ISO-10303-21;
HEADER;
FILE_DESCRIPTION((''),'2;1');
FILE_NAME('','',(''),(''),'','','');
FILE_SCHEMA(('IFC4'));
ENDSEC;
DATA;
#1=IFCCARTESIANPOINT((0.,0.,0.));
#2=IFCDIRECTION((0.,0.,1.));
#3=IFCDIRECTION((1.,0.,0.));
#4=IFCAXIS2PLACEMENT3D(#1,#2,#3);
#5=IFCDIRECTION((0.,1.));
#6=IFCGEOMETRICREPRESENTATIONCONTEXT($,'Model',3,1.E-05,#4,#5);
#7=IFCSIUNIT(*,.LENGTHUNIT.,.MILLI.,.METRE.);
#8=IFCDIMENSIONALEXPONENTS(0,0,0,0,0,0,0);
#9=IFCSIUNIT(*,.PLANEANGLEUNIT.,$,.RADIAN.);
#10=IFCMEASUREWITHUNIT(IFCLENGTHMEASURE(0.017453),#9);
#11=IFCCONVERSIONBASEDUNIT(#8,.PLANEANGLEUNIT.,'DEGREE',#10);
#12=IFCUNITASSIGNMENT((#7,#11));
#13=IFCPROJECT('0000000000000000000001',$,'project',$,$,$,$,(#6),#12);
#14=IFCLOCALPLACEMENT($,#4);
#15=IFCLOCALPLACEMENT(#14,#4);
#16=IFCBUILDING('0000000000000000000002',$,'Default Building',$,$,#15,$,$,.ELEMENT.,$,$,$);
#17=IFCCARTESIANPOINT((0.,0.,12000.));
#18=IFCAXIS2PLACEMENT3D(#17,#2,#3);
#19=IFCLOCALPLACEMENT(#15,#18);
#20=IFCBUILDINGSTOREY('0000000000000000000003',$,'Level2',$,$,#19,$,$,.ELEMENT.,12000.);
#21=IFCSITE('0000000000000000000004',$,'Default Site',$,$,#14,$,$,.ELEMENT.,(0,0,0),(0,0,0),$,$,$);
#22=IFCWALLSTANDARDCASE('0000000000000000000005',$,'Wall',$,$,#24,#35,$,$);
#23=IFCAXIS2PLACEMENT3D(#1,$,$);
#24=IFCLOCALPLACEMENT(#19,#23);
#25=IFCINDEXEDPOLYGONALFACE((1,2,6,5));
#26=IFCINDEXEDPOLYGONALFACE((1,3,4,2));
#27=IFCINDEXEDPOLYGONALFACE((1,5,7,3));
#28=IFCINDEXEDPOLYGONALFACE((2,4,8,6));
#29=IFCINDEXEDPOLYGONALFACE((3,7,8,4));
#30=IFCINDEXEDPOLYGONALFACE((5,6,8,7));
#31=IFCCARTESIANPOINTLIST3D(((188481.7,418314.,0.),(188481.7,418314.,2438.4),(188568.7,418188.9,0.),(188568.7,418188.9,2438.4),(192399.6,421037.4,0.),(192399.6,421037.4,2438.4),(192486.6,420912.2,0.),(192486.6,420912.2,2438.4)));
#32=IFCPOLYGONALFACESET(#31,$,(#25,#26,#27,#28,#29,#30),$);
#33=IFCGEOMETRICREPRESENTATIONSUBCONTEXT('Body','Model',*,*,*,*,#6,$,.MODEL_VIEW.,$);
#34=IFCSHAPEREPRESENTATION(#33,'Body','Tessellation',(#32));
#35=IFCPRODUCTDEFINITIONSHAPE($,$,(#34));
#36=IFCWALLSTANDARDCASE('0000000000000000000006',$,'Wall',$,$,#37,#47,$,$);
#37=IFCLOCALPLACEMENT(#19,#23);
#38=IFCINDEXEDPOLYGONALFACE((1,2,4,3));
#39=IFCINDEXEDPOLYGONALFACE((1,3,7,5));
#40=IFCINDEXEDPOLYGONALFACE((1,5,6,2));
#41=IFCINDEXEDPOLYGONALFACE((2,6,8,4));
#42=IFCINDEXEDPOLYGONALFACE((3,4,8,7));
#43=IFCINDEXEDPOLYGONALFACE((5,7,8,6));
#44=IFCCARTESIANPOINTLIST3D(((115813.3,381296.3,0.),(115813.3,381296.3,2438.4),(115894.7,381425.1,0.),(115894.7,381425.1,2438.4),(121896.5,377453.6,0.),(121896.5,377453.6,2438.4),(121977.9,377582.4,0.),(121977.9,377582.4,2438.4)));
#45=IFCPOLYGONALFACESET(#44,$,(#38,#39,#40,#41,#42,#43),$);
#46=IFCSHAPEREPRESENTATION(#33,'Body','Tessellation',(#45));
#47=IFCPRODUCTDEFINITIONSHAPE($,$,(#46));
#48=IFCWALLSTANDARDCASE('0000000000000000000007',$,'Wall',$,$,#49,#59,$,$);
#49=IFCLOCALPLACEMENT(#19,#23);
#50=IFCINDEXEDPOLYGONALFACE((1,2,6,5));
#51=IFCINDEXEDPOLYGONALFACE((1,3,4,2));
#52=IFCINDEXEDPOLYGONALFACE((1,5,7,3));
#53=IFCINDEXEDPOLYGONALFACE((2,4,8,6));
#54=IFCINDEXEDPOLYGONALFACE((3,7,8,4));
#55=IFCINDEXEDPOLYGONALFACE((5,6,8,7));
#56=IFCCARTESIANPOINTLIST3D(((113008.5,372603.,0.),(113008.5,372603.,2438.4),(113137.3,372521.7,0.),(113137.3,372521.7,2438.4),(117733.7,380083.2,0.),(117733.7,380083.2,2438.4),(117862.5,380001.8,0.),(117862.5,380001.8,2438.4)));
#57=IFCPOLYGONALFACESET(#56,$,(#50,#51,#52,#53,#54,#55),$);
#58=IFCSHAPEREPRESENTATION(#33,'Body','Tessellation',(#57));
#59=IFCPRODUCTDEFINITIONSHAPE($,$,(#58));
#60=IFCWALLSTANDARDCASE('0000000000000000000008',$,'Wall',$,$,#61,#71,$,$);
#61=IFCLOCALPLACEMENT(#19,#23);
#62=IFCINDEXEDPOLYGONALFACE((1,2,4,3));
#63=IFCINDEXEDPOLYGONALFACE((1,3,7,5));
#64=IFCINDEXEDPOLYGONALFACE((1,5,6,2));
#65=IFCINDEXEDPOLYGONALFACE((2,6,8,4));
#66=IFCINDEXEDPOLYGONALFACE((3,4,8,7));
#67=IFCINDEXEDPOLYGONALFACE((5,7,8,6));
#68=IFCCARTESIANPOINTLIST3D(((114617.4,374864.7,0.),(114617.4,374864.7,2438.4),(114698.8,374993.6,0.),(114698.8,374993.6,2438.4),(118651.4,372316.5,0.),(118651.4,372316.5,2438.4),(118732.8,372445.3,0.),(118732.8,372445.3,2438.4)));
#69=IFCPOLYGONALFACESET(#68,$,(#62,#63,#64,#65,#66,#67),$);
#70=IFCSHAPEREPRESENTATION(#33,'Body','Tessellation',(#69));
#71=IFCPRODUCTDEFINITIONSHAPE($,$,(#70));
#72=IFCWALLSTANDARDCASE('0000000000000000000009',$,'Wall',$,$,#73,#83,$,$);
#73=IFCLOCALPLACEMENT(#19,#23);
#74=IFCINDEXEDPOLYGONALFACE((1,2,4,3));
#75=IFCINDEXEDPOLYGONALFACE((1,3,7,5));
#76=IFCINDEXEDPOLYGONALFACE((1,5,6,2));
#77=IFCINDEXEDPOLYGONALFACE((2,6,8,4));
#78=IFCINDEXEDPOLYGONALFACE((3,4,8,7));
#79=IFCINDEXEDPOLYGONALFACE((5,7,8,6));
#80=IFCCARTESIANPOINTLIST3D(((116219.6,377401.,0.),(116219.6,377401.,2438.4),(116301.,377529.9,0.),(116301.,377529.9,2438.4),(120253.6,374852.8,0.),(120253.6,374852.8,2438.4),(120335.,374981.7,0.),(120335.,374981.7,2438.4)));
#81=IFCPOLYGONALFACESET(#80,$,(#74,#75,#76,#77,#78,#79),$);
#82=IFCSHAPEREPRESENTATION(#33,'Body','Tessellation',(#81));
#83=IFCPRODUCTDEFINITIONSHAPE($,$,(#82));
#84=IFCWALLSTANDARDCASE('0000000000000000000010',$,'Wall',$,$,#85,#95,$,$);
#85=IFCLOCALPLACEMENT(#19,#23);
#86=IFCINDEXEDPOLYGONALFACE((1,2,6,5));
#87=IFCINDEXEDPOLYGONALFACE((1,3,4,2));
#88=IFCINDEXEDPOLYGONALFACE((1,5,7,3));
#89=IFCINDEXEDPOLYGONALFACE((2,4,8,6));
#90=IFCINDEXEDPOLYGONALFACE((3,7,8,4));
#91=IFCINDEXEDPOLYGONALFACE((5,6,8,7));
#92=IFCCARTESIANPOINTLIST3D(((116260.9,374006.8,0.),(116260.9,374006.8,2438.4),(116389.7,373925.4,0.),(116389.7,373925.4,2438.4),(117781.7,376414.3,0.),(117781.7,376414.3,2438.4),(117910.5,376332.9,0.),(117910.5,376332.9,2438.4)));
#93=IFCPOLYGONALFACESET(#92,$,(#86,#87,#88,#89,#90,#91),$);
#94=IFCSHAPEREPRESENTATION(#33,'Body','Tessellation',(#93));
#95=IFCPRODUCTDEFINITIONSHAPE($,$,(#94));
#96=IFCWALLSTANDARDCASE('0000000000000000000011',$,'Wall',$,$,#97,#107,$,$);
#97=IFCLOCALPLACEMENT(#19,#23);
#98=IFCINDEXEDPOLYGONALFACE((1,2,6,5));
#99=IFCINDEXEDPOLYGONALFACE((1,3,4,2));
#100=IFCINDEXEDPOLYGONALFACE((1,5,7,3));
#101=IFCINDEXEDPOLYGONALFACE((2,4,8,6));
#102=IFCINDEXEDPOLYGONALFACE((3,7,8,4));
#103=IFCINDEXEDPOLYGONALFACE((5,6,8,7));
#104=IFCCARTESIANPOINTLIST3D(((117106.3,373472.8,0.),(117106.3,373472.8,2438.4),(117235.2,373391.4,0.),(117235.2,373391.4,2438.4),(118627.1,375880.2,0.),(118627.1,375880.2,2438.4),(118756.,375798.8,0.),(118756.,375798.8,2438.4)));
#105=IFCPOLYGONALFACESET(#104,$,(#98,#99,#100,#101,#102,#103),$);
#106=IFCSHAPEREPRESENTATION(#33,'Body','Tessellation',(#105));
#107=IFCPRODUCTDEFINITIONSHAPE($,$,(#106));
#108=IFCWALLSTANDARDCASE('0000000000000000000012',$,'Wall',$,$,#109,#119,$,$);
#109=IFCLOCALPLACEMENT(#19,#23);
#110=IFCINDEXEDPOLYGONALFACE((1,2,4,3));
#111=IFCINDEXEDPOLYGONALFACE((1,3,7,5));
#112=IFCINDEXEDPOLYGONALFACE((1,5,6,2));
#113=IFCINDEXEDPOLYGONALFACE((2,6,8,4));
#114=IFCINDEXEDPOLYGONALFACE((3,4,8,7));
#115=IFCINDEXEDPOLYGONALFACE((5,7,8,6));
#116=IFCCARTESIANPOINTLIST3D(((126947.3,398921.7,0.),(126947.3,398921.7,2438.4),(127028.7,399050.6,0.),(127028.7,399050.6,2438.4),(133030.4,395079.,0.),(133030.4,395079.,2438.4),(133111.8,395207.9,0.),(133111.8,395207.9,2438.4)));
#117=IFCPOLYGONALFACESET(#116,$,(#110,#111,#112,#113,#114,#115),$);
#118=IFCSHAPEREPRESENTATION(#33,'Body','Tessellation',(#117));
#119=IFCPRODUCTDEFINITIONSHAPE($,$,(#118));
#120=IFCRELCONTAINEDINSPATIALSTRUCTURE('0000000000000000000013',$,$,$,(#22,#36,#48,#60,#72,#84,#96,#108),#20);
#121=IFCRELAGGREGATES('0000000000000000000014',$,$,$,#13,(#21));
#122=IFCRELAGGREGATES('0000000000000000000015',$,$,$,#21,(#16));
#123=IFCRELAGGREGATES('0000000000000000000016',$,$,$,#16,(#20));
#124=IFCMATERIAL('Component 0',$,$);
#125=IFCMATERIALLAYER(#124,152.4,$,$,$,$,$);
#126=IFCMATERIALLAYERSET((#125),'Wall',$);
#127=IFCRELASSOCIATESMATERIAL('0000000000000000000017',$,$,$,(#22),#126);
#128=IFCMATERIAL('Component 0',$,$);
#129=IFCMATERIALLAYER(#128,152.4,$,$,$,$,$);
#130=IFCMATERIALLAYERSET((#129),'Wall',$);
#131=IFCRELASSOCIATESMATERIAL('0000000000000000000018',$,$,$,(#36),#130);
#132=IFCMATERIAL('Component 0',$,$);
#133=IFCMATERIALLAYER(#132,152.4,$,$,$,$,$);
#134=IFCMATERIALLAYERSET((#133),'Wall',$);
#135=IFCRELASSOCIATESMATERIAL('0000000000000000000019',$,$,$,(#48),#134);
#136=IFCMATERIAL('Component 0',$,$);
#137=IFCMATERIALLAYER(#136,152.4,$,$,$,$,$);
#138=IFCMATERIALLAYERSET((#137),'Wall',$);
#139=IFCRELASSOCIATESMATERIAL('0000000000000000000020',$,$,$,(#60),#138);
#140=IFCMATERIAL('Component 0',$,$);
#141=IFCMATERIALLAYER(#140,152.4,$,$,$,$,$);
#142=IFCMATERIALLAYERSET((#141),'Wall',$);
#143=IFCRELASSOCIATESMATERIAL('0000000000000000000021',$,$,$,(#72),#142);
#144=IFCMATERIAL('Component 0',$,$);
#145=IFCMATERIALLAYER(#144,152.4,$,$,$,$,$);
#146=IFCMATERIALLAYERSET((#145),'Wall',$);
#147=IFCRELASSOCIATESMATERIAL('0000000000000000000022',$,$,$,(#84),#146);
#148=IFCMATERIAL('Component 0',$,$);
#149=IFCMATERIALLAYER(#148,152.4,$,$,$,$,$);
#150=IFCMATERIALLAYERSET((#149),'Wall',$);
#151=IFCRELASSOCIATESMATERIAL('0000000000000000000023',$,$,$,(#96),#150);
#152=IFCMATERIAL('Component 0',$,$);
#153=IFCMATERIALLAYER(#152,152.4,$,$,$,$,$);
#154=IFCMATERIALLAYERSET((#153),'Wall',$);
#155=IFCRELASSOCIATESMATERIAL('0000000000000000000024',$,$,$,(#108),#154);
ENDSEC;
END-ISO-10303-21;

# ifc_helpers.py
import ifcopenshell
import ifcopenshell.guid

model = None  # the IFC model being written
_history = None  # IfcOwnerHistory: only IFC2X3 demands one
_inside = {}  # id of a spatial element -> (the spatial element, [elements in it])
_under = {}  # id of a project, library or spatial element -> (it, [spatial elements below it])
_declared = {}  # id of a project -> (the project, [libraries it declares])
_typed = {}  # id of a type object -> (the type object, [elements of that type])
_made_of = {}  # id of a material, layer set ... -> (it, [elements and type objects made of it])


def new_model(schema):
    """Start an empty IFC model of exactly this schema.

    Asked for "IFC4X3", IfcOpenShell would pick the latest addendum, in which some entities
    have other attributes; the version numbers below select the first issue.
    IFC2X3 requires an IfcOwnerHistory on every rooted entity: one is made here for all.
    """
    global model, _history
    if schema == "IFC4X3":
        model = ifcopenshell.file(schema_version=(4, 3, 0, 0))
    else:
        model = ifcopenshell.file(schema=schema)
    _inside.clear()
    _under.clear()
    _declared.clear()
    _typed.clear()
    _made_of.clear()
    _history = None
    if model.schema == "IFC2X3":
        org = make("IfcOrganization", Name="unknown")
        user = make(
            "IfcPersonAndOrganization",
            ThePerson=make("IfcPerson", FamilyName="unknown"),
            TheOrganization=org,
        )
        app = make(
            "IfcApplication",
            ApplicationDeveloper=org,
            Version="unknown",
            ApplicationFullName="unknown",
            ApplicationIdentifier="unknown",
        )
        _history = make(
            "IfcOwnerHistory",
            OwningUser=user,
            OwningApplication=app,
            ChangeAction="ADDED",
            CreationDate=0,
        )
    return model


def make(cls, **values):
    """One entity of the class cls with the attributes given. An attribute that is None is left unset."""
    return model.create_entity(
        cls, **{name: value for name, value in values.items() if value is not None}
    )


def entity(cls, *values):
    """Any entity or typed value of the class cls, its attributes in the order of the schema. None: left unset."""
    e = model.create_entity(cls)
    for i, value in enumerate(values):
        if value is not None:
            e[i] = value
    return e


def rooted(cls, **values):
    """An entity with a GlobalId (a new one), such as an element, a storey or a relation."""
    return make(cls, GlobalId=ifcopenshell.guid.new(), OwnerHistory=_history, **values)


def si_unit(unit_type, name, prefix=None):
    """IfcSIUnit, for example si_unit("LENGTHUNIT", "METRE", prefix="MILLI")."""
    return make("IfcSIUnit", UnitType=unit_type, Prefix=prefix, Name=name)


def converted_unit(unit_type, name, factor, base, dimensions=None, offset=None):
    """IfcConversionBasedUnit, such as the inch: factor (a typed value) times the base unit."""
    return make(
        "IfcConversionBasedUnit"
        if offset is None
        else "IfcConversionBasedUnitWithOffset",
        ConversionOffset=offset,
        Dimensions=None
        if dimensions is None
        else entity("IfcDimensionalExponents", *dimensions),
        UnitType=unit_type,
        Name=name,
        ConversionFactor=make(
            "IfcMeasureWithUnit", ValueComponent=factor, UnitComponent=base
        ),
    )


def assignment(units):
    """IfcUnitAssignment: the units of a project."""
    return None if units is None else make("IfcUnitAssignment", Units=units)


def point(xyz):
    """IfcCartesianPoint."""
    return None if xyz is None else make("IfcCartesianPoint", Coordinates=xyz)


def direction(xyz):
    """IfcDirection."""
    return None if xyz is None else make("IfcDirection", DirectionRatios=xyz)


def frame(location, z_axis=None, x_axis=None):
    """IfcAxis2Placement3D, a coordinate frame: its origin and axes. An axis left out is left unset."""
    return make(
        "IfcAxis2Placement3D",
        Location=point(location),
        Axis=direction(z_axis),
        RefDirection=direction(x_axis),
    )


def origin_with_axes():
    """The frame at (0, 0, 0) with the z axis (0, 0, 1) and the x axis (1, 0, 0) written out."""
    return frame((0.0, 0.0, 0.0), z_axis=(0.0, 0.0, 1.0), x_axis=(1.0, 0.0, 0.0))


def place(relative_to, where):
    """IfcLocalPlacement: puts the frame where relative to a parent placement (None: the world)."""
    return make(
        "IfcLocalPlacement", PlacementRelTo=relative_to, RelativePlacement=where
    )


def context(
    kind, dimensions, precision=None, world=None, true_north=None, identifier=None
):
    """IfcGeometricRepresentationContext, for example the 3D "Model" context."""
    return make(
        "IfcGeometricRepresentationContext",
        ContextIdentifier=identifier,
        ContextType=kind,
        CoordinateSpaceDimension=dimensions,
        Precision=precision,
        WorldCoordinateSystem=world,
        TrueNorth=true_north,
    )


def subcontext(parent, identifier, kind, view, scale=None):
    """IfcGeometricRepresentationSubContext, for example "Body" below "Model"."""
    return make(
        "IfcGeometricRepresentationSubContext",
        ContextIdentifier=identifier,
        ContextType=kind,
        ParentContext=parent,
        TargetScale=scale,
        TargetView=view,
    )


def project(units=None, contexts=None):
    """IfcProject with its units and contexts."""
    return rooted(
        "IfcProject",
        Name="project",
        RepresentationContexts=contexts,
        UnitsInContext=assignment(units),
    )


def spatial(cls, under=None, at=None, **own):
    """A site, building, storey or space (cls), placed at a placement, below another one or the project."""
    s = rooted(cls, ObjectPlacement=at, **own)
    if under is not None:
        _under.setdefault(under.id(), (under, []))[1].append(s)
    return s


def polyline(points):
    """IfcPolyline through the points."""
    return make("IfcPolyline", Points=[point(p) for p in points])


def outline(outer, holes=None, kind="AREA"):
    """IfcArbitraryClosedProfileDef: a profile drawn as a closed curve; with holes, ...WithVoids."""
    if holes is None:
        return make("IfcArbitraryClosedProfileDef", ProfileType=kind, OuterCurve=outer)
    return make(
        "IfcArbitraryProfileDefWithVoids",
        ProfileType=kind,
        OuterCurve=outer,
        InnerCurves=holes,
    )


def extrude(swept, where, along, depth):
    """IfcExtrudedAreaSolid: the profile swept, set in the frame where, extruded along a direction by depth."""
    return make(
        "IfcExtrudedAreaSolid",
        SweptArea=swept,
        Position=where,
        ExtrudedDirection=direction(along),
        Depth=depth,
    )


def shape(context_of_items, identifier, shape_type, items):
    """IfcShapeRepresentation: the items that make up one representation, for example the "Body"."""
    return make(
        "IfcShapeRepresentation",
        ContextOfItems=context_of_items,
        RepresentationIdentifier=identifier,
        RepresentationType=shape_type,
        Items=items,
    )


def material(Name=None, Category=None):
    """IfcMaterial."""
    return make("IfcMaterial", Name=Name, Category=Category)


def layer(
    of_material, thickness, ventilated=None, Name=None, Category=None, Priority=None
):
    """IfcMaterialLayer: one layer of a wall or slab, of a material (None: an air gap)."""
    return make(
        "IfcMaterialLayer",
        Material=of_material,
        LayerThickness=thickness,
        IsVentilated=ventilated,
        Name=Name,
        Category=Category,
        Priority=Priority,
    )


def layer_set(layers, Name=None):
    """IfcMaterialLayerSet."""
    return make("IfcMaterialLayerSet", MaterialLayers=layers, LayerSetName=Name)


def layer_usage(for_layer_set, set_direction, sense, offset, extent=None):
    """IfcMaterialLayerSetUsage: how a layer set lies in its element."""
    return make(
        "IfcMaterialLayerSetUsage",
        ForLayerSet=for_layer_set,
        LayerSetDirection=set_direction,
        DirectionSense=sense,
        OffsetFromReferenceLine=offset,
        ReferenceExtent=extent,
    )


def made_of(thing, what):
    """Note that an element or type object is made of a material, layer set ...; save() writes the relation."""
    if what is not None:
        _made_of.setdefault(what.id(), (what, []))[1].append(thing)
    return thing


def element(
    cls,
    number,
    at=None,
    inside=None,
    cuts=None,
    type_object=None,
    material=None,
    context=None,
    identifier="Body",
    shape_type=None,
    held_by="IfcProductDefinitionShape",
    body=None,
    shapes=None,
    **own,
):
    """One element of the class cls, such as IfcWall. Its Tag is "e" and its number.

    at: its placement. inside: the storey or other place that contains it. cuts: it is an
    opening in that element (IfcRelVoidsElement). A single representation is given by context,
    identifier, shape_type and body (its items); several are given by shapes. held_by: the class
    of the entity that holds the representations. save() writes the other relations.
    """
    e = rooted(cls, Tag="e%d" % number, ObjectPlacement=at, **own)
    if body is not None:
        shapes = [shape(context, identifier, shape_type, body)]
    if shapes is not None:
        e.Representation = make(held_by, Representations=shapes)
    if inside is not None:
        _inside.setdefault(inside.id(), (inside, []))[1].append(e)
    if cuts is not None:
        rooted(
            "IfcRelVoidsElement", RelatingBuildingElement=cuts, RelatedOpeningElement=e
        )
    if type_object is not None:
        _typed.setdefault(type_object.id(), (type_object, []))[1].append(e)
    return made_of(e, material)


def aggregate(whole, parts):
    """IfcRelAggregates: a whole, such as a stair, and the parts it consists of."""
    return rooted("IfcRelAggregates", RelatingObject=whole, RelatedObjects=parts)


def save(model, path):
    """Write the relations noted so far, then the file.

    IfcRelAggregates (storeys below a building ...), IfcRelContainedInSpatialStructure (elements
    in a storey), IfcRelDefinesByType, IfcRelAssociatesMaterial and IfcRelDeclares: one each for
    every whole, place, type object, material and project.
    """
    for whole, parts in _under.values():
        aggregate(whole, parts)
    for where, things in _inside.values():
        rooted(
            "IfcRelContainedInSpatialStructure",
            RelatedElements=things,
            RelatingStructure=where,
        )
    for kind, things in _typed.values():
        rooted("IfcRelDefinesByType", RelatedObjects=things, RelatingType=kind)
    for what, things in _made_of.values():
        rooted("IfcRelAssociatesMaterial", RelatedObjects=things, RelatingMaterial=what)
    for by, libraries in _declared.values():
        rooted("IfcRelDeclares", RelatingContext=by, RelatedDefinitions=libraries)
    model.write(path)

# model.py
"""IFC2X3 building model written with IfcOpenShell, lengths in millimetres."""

from ifc_helpers import new_model, entity, si_unit, converted_unit, direction, frame, origin_with_axes, place, context, subcontext, project, spatial, polyline, outline, extrude, material, layer, layer_set, layer_usage, element, save


model = new_model("IFC2X3")

# Units and contexts
model_context = context("Model", 3, precision=1e-05, world=origin_with_axes(), true_north=direction((0.0, 1.0)))
body_context = subcontext(model_context, "Body", "Model", "MODEL_VIEW")
ifc_project = project(units=[si_unit("LENGTHUNIT", "METRE", prefix="MILLI"), converted_unit("PLANEANGLEUNIT", "DEGREE", entity("IfcLengthMeasure", 0.017453), si_unit("PLANEANGLEUNIT", "RADIAN"), dimensions=[0, 0, 0, 0, 0, 0, 0])], contexts=[model_context])

# Site, building, storey
site_placement = place(None, origin_with_axes())
site = spatial("IfcSite", under=ifc_project, at=site_placement, Name="Default Site", CompositionType="ELEMENT", RefLatitude=(0, 0, 0), RefLongitude=(0, 0, 0))
building_placement = place(site_placement, origin_with_axes())
building = spatial("IfcBuilding", under=site, at=building_placement, Name="Default Building", CompositionType="ELEMENT")
storey_placement = place(building_placement, frame((0.0, 0.0, 12000.0), z_axis=(0.0, 0.0, 1.0), x_axis=(1.0, 0.0, 0.0)))
storey = spatial("IfcBuildingStorey", under=building, at=storey_placement, Name="Level2", CompositionType="ELEMENT", Elevation=12000.0)

# Walls
ifc_material_1 = material(Name="Component 0")
ifc_layer_1 = layer(ifc_material_1, 152.4)
ifc_layer_set_1 = layer_set([ifc_layer_1], Name="Wall")
ifc_layer_usage_1 = layer_usage(ifc_layer_set_1, "AXIS2", "POSITIVE", -76.2)
wall_1_placement = place(storey_placement, frame((188462.7, 418208.0, 0.0), z_axis=(0.0, 0.0, 1.0), x_axis=(0.82112, 0.570755, 0.0)))
element("IfcWallStandardCase", 1, at=wall_1_placement, inside=storey, material=ifc_layer_usage_1, Name="Wall", context=body_context, shape_type="SweptSolid", body=[
    extrude(outline(polyline([(76.2, -76.2), (76.2, 76.2), (4847.6, 76.2), (4847.6, -76.2), (76.2, -76.2)])), origin_with_axes(), (0.0, 0.0, 1.0), 2438.4),
])
ifc_material_2 = material(Name="Component 0")
ifc_layer_2 = layer(ifc_material_2, 152.4)
ifc_layer_set_2 = layer_set([ifc_layer_2], Name="Wall")
ifc_layer_usage_2 = layer_usage(ifc_layer_set_2, "AXIS2", "POSITIVE", -76.2)
wall_2_placement = place(storey_placement, frame((122001.6, 377477.3, 0.0), z_axis=(0.0, 0.0, 1.0), x_axis=(-0.845443, 0.534065, 0.0)))
element("IfcWallStandardCase", 2, at=wall_2_placement, inside=storey, material=ifc_layer_usage_2, Name="Wall", context=body_context, shape_type="SweptSolid", body=[
    extrude(outline(polyline([(76.2, -76.2), (76.2, 76.2), (7271.4, 76.2), (7271.4, -76.2), (76.2, -76.2)])), origin_with_axes(), (0.0, 0.0, 1.0), 2438.4),
])
ifc_material_3 = material(Name="Component 0")
ifc_layer_3 = layer(ifc_material_3, 152.4)
ifc_layer_set_3 = layer_set([ifc_layer_3], Name="Wall")
ifc_layer_usage_3 = layer_usage(ifc_layer_set_3, "AXIS2", "POSITIVE", -76.2)
wall_3_placement = place(storey_placement, frame((113032.2, 372497.9, 0.0), z_axis=(0.0, 0.0, 1.0), x_axis=(0.534065, 0.845443, 0.0)))
element("IfcWallStandardCase", 3, at=wall_3_placement, inside=storey, material=ifc_layer_usage_3, Name="Wall", context=body_context, shape_type="SweptSolid", body=[
    extrude(outline(polyline([(76.2, -76.2), (76.2, 76.2), (8923.8, 76.2), (8923.8, -76.2), (76.2, -76.2)])), origin_with_axes(), (0.0, 0.0, 1.0), 2438.4),
])
ifc_material_4 = material(Name="Component 0")
ifc_layer_4 = layer(ifc_material_4, 152.4)
ifc_layer_set_4 = layer_set([ifc_layer_4], Name="Wall")
ifc_layer_usage_4 = layer_usage(ifc_layer_set_4, "AXIS2", "POSITIVE", -76.2)
wall_4_placement = place(storey_placement, frame((114593.7, 374969.8, 0.0), z_axis=(0.0, 0.0, 1.0), x_axis=(0.845443, -0.534065, 0.0)))
element("IfcWallStandardCase", 4, at=wall_4_placement, inside=storey, material=ifc_layer_usage_4, Name="Wall", context=body_context, shape_type="SweptSolid", body=[
    extrude(outline(polyline([(76.2, -76.2), (76.2, 76.2), (4847.6, 76.2), (4847.6, -76.2), (76.2, -76.2)])), origin_with_axes(), (0.0, 0.0, 1.0), 2438.4),
])
ifc_material_5 = material(Name="Component 0")
ifc_layer_5 = layer(ifc_material_5, 152.4)
ifc_layer_set_5 = layer_set([ifc_layer_5], Name="Wall")
ifc_layer_usage_5 = layer_usage(ifc_layer_set_5, "AXIS2", "POSITIVE", -76.2)
wall_5_placement = place(storey_placement, frame((116195.9, 377506.2, 0.0), z_axis=(0.0, 0.0, 1.0), x_axis=(0.845443, -0.534065, 0.0)))
element("IfcWallStandardCase", 5, at=wall_5_placement, inside=storey, material=ifc_layer_usage_5, Name="Wall", context=body_context, shape_type="SweptSolid", body=[
    extrude(outline(polyline([(76.2, -76.2), (76.2, 76.2), (4847.6, 76.2), (4847.6, -76.2), (76.2, -76.2)])), origin_with_axes(), (0.0, 0.0, 1.0), 2438.4),
])
ifc_material_6 = material(Name="Component 0")
ifc_layer_6 = layer(ifc_material_6, 152.4)
ifc_layer_set_6 = layer_set([ifc_layer_6], Name="Wall")
ifc_layer_usage_6 = layer_usage(ifc_layer_set_6, "AXIS2", "POSITIVE", -76.2)
wall_6_placement = place(storey_placement, frame((116284.6, 373901.7, 0.0), z_axis=(0.0, 0.0, 1.0), x_axis=(0.534065, 0.845443, 0.0)))
element("IfcWallStandardCase", 6, at=wall_6_placement, inside=storey, material=ifc_layer_usage_6, Name="Wall", context=body_context, shape_type="SweptSolid", body=[
    extrude(outline(polyline([(76.2, -76.2), (76.2, 76.2), (2923.8, 76.2), (2923.8, -76.2), (76.2, -76.2)])), origin_with_axes(), (0.0, 0.0, 1.0), 2438.4),
])
ifc_material_7 = material(Name="Component 0")
ifc_layer_7 = layer(ifc_material_7, 152.4)
ifc_layer_set_7 = layer_set([ifc_layer_7], Name="Wall")
ifc_layer_usage_7 = layer_usage(ifc_layer_set_7, "AXIS2", "POSITIVE", -76.2)
wall_7_placement = place(storey_placement, frame((117130.0, 373367.6, 0.0), z_axis=(0.0, 0.0, 1.0), x_axis=(0.534065, 0.845443, 0.0)))
element("IfcWallStandardCase", 7, at=wall_7_placement, inside=storey, material=ifc_layer_usage_7, Name="Wall", context=body_context, shape_type="SweptSolid", body=[
    extrude(outline(polyline([(76.2, -76.2), (76.2, 76.2), (2923.8, 76.2), (2923.8, -76.2), (76.2, -76.2)])), origin_with_axes(), (0.0, 0.0, 1.0), 2438.4),
])
ifc_material_8 = material(Name="Component 0")
ifc_layer_8 = layer(ifc_material_8, 152.4)
ifc_layer_set_8 = layer_set([ifc_layer_8], Name="Wall")
ifc_layer_usage_8 = layer_usage(ifc_layer_set_8, "AXIS2", "POSITIVE", -76.2)
wall_8_placement = place(storey_placement, frame((126923.6, 399026.8, 0.0), z_axis=(0.0, 0.0, 1.0), x_axis=(0.845443, -0.534065, 0.0)))
element("IfcWallStandardCase", 8, at=wall_8_placement, inside=storey, material=ifc_layer_usage_8, Name="Wall", context=body_context, shape_type="SweptSolid", body=[
    extrude(outline(polyline([(76.2, -76.2), (76.2, 76.2), (7271.4, 76.2), (7271.4, -76.2), (76.2, -76.2)])), origin_with_axes(), (0.0, 0.0, 1.0), 2438.4),
])

save(model, "model.ifc")
